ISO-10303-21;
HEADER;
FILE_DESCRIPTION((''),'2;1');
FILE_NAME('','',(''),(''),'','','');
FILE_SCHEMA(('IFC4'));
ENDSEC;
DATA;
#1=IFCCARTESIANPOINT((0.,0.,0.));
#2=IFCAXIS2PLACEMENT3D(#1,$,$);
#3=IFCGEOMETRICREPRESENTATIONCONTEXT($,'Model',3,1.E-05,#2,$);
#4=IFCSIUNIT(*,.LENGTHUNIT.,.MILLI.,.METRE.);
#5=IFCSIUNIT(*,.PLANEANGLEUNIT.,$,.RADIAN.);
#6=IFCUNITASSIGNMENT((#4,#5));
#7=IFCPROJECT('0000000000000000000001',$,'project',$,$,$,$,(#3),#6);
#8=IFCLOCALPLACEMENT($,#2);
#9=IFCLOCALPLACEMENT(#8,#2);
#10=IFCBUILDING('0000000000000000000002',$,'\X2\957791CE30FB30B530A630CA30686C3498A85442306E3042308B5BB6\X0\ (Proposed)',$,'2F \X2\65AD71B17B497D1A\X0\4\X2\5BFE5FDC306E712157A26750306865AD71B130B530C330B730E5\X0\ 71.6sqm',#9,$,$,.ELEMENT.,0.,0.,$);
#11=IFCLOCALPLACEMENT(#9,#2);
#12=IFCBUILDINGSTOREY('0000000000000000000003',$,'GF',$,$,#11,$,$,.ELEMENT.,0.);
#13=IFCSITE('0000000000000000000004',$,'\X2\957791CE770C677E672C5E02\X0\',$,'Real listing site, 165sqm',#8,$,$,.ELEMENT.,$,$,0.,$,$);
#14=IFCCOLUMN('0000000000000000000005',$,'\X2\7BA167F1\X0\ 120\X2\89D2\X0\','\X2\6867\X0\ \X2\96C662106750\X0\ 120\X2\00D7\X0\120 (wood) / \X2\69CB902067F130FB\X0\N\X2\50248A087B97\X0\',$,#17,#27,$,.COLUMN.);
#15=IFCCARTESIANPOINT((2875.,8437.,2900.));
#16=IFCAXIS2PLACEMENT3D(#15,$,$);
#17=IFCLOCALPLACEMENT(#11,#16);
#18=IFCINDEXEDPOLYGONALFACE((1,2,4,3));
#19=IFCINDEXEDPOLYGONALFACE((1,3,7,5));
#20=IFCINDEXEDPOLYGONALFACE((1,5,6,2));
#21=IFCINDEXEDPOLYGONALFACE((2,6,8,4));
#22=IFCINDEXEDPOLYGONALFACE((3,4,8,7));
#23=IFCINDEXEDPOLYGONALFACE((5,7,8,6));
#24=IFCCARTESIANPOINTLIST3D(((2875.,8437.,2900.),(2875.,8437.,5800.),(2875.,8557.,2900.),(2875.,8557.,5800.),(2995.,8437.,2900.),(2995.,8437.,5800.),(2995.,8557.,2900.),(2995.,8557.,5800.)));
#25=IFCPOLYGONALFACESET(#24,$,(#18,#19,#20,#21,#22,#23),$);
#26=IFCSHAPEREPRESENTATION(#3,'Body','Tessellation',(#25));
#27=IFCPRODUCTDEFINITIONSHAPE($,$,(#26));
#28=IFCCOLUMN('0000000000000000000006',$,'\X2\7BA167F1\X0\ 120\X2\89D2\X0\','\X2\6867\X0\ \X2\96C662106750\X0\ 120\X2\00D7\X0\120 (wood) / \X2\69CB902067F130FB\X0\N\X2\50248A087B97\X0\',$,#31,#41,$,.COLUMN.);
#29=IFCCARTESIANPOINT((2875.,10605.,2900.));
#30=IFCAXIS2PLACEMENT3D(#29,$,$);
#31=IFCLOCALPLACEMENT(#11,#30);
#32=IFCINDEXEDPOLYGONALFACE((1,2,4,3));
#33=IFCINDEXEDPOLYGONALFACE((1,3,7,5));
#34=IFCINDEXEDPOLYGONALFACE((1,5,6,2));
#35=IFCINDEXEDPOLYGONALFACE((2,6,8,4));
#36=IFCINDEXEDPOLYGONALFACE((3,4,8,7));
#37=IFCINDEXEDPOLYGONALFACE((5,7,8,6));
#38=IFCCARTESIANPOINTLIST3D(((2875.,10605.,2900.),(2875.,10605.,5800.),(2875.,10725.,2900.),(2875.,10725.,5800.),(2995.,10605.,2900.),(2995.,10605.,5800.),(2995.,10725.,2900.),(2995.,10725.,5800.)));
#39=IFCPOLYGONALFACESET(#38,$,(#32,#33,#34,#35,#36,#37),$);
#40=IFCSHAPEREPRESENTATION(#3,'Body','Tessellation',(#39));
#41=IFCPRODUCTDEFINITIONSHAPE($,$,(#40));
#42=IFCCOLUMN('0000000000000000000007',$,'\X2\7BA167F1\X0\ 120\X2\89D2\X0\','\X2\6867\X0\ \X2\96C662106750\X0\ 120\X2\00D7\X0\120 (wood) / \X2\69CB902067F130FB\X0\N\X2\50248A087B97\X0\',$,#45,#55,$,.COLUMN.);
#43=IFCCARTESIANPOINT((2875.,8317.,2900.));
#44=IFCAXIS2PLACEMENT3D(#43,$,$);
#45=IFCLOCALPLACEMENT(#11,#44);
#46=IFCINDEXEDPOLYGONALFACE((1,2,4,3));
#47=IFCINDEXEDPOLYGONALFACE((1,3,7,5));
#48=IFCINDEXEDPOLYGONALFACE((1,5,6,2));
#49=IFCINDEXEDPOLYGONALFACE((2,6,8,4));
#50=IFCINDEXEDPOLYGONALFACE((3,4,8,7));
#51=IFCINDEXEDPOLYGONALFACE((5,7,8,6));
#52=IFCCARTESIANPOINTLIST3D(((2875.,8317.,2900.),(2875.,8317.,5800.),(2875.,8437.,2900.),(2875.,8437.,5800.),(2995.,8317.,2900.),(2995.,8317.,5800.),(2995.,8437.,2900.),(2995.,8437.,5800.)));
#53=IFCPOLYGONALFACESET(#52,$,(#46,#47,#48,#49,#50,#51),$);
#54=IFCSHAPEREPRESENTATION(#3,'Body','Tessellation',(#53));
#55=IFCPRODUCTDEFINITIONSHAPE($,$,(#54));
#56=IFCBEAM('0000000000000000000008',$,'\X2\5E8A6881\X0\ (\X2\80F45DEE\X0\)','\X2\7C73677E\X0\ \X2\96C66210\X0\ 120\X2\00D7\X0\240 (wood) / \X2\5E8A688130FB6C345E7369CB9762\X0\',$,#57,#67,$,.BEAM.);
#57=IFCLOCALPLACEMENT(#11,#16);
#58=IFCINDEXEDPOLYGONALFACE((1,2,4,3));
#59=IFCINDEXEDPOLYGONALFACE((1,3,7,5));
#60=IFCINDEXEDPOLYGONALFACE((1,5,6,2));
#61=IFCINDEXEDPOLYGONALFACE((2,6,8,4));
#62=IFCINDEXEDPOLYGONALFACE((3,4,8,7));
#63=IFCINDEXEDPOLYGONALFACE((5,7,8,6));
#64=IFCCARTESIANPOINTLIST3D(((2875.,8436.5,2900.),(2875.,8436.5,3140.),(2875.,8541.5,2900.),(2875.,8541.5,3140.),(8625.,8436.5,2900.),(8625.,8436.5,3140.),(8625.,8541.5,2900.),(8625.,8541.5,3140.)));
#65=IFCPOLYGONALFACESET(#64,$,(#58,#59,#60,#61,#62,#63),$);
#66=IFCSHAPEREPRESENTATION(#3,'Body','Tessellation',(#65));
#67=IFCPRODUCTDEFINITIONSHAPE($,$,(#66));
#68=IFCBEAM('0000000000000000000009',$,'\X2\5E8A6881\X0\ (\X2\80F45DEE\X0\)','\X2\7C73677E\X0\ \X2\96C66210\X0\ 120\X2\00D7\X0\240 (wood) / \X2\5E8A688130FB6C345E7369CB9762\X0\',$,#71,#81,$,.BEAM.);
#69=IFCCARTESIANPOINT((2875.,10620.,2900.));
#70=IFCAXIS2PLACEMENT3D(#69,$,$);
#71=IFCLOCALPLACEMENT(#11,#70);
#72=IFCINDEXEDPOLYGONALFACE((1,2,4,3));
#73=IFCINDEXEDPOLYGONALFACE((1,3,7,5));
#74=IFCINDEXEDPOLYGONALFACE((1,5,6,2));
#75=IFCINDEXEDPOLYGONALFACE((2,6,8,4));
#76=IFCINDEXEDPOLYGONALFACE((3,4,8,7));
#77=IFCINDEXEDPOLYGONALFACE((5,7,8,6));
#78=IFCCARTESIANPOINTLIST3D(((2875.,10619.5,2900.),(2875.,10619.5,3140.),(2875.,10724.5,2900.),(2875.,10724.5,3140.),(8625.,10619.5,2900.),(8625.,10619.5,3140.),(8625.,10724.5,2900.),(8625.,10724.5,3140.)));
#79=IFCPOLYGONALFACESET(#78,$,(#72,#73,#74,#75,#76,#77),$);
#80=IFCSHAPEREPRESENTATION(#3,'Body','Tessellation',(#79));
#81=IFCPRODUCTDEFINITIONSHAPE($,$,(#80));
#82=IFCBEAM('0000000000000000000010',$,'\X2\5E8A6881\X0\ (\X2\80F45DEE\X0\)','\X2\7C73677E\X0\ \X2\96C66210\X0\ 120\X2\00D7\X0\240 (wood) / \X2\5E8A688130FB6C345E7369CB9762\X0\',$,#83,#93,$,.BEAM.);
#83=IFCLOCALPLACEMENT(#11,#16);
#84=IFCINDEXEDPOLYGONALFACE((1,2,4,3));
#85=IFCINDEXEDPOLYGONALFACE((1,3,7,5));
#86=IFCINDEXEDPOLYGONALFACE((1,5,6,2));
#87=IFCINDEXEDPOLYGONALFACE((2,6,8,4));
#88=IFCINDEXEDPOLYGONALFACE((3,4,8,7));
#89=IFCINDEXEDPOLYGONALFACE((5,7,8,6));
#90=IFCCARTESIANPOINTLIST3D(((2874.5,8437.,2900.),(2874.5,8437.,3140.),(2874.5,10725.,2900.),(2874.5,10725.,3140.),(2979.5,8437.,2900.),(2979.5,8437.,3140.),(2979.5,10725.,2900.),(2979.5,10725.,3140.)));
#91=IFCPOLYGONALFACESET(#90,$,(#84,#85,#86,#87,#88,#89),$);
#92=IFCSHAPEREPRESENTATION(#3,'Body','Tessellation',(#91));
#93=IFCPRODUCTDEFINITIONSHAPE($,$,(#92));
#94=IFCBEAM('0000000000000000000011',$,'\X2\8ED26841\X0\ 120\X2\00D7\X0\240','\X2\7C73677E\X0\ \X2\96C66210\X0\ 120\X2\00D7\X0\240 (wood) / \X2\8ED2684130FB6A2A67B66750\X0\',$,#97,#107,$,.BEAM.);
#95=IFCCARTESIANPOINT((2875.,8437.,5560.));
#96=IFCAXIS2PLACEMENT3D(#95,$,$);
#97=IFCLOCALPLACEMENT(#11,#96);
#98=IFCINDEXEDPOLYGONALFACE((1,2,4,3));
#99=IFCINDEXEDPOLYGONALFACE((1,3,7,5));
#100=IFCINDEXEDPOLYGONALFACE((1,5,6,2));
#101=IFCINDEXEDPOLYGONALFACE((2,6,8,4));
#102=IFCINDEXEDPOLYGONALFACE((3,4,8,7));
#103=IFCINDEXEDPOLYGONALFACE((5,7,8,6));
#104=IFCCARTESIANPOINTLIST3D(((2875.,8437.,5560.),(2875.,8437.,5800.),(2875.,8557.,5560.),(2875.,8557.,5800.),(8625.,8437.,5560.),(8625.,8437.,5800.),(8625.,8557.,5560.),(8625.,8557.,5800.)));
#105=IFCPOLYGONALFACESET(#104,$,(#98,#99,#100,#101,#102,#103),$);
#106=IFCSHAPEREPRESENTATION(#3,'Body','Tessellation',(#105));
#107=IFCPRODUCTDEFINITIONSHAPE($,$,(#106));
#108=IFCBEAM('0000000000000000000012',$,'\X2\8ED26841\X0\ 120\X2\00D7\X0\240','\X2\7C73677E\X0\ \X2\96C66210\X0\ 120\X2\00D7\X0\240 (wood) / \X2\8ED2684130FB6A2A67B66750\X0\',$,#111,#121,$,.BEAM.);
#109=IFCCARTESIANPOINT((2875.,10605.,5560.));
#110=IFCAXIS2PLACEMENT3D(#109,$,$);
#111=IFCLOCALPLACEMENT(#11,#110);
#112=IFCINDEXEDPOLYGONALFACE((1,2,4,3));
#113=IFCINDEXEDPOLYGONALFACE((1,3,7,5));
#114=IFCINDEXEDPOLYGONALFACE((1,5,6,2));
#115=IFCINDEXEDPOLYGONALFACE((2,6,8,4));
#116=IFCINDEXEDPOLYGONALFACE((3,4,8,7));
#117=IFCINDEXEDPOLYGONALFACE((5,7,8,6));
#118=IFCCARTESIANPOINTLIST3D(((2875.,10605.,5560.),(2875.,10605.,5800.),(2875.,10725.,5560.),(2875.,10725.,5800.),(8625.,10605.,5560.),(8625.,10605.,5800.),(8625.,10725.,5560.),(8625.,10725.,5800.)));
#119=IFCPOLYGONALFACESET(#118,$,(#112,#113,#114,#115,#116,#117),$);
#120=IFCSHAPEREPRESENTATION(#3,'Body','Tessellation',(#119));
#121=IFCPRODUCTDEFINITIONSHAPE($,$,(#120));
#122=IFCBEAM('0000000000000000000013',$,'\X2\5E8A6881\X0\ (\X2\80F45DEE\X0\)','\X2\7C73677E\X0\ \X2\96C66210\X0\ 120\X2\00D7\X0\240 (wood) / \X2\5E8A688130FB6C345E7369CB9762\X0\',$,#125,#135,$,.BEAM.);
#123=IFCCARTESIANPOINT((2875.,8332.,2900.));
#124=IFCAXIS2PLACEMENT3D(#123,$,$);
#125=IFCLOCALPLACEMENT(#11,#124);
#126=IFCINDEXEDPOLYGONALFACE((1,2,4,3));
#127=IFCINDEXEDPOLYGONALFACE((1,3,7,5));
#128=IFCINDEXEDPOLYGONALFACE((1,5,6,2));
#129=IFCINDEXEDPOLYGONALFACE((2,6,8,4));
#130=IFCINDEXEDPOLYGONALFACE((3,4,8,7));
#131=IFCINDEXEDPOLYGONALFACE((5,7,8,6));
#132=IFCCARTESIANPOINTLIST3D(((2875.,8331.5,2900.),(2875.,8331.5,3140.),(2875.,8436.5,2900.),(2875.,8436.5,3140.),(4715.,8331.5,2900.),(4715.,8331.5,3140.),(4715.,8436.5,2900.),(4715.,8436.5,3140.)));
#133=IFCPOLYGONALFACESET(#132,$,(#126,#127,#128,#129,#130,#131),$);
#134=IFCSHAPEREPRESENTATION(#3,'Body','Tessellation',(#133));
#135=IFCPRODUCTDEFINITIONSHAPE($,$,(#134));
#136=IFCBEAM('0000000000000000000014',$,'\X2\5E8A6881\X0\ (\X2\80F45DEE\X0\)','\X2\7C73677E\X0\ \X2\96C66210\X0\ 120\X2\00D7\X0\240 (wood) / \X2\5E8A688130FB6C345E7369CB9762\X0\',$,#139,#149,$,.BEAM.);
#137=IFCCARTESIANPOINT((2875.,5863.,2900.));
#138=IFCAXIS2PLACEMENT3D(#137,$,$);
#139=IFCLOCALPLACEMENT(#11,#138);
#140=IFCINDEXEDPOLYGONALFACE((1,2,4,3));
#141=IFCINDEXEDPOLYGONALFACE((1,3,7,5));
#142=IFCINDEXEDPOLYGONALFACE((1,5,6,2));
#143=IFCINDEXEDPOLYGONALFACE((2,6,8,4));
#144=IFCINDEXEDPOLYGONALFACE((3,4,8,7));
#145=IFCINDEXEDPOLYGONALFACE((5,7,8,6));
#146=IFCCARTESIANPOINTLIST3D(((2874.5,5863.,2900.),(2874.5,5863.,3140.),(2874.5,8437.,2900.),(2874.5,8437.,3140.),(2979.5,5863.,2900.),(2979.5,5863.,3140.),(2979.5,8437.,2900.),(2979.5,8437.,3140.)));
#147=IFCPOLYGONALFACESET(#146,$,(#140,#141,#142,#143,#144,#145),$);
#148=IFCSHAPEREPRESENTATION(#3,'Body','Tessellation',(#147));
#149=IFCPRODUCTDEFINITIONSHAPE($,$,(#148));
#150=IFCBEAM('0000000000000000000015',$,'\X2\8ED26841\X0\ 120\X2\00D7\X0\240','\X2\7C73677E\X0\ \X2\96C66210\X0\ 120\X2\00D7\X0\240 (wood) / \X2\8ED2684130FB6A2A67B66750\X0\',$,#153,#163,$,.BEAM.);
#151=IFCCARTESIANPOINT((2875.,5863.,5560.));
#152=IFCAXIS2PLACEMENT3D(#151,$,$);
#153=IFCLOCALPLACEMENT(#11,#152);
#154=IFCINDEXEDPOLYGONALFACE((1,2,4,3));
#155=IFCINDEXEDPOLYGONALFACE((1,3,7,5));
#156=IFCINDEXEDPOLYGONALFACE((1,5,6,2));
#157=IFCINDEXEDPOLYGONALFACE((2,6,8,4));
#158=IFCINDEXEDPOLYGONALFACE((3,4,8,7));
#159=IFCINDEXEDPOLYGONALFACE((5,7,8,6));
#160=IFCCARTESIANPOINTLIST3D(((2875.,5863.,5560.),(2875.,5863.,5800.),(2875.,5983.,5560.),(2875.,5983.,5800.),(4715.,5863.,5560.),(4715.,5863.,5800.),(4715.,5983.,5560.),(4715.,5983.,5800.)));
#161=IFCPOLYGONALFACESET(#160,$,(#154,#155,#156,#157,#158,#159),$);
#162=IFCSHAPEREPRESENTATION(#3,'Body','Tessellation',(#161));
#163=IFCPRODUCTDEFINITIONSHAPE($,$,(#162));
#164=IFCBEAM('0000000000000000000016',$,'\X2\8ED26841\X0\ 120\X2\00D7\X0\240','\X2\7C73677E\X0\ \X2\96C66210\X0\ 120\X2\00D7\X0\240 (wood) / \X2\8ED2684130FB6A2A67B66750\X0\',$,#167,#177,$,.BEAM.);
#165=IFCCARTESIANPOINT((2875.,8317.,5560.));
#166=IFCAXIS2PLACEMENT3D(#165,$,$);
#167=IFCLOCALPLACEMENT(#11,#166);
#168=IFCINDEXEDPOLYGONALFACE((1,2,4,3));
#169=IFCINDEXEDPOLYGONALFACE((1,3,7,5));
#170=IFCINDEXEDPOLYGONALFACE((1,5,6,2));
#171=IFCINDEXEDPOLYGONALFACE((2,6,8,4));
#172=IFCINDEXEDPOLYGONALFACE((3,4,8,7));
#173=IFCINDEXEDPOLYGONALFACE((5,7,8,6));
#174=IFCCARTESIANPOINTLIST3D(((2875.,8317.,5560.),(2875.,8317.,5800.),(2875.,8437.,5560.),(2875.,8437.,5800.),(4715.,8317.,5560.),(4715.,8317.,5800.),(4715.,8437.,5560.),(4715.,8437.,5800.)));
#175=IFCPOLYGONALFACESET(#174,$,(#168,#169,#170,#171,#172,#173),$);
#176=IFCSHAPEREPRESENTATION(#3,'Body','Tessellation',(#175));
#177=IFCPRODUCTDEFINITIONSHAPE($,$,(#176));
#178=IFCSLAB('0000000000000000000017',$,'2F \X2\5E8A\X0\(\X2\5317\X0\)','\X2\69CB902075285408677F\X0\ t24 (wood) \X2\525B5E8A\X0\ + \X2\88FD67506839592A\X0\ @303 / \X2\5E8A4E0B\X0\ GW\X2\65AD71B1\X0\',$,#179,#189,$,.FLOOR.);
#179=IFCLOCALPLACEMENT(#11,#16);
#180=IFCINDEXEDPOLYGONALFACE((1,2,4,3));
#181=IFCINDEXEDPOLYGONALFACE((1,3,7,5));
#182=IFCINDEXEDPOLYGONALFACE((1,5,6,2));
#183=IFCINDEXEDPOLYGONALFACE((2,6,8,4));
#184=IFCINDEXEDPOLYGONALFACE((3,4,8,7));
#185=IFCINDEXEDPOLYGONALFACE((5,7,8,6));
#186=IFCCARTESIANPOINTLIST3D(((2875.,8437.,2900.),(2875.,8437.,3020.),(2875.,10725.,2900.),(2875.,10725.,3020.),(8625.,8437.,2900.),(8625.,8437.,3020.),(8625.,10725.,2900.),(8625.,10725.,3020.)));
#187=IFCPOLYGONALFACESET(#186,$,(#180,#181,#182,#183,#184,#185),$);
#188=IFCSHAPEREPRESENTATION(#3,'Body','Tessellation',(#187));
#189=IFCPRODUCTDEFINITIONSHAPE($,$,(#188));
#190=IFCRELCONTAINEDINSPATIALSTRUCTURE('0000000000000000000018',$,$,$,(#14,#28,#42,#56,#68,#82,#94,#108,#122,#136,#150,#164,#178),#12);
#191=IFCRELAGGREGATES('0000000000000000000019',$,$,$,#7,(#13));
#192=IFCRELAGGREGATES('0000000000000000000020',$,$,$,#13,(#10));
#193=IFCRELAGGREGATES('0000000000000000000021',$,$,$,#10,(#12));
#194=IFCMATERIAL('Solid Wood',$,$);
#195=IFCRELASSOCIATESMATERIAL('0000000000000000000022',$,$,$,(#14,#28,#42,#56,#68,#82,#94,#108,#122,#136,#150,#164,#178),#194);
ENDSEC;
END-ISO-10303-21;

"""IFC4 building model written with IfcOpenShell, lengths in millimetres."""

from ifc_helpers import new_model, si_unit, frame, frame_2d, origin, place, context, project, spatial, rectangle, extrude, material, element, save


model = new_model("IFC4")

# Units and contexts
model_context = context("Model", 3, precision=1e-05, world=origin())
ifc_project = project(units=[si_unit("LENGTHUNIT", "METRE", prefix="MILLI"), si_unit("PLANEANGLEUNIT", "RADIAN")], contexts=[model_context])

# Site, building, storey
site_placement = place(None, origin())
site = spatial("IfcSite", under=ifc_project, at=site_placement, Name="長野県松本市", ObjectType="Real listing site, 165sqm", CompositionType="ELEMENT", RefElevation=0.0)
building_placement = place(site_placement, origin())
building = spatial("IfcBuilding", under=site, at=building_placement, Name="長野・サウナと水風呂のある家 (Proposed)", ObjectType="2F 断熱等級4対応の無垢材と断熱サッシュ 71.6sqm", CompositionType="ELEMENT", ElevationOfRefHeight=0.0, ElevationOfTerrain=0.0)
storey_placement = place(building_placement, origin())
storey = spatial("IfcBuildingStorey", under=building, at=storey_placement, Name="GF", CompositionType="ELEMENT", Elevation=0.0)

# Columns
ifc_material_1 = material(Name="Solid Wood")
column_1_placement = place(storey_placement, frame((2875.0, 8437.0, 2900.0)))
element("IfcColumn", 1, at=column_1_placement, inside=storey, material=ifc_material_1, Name="管柱 120角", Description="桧 集成材 120×120 (wood) / 構造柱・N値計算", PredefinedType="COLUMN", context=model_context, shape_type="SweptSolid", body=[
    extrude(rectangle(XDim=120.0, YDim=120.0, at=frame_2d((60.0, 60.0))), frame((2875.0, 8437.0, 2900.0)), (0.0, 0.0, 1.0), 2900.0),
])
column_2_placement = place(storey_placement, frame((2875.0, 10605.0, 2900.0)))
element("IfcColumn", 2, at=column_2_placement, inside=storey, material=ifc_material_1, Name="管柱 120角", Description="桧 集成材 120×120 (wood) / 構造柱・N値計算", PredefinedType="COLUMN", context=model_context, shape_type="SweptSolid", body=[
    extrude(rectangle(XDim=120.0, YDim=120.0, at=frame_2d((60.0, 60.0))), frame((2875.0, 10605.0, 2900.0)), (0.0, 0.0, 1.0), 2900.0),
])
column_3_placement = place(storey_placement, frame((2875.0, 8317.0, 2900.0)))
element("IfcColumn", 3, at=column_3_placement, inside=storey, material=ifc_material_1, Name="管柱 120角", Description="桧 集成材 120×120 (wood) / 構造柱・N値計算", PredefinedType="COLUMN", context=model_context, shape_type="SweptSolid", body=[
    extrude(rectangle(XDim=120.0, YDim=120.0, at=frame_2d((60.0, 60.0))), frame((2875.0, 8317.0, 2900.0)), (0.0, 0.0, 1.0), 2900.0),
])

# Beams
beam_1_placement = place(storey_placement, frame((2875.0, 8437.0, 2900.0)))
element("IfcBeam", 4, at=beam_1_placement, inside=storey, material=ifc_material_1, Name="床梁 (胴差)", Description="米松 集成 120×240 (wood) / 床梁・水平構面", PredefinedType="BEAM", context=model_context, shape_type="SweptSolid", body=[
    extrude(rectangle(XDim=5750.0, YDim=105.0, at=frame_2d((2875.0, 52.0))), frame((2875.0, 8437.0, 2900.0)), (0.0, 0.0, 1.0), 240.0),
])
beam_2_placement = place(storey_placement, frame((2875.0, 10620.0, 2900.0)))
element("IfcBeam", 5, at=beam_2_placement, inside=storey, material=ifc_material_1, Name="床梁 (胴差)", Description="米松 集成 120×240 (wood) / 床梁・水平構面", PredefinedType="BEAM", context=model_context, shape_type="SweptSolid", body=[
    extrude(rectangle(XDim=5750.0, YDim=105.0, at=frame_2d((2875.0, 52.0))), frame((2875.0, 10620.0, 2900.0)), (0.0, 0.0, 1.0), 240.0),
])
beam_3_placement = place(storey_placement, frame((2875.0, 8437.0, 2900.0)))
element("IfcBeam", 6, at=beam_3_placement, inside=storey, material=ifc_material_1, Name="床梁 (胴差)", Description="米松 集成 120×240 (wood) / 床梁・水平構面", PredefinedType="BEAM", context=model_context, shape_type="SweptSolid", body=[
    extrude(rectangle(XDim=105.0, YDim=2288.0, at=frame_2d((52.0, 1144.0))), frame((2875.0, 8437.0, 2900.0)), (0.0, 0.0, 1.0), 240.0),
])
beam_4_placement = place(storey_placement, frame((2875.0, 8437.0, 5560.0)))
element("IfcBeam", 7, at=beam_4_placement, inside=storey, material=ifc_material_1, Name="軒桁 120×240", Description="米松 集成 120×240 (wood) / 軒桁・横架材", PredefinedType="BEAM", context=model_context, shape_type="SweptSolid", body=[
    extrude(rectangle(XDim=5750.0, YDim=120.0, at=frame_2d((2875.0, 60.0))), frame((2875.0, 8437.0, 5560.0)), (0.0, 0.0, 1.0), 240.0),
])
beam_5_placement = place(storey_placement, frame((2875.0, 10605.0, 5560.0)))
element("IfcBeam", 8, at=beam_5_placement, inside=storey, material=ifc_material_1, Name="軒桁 120×240", Description="米松 集成 120×240 (wood) / 軒桁・横架材", PredefinedType="BEAM", context=model_context, shape_type="SweptSolid", body=[
    extrude(rectangle(XDim=5750.0, YDim=120.0, at=frame_2d((2875.0, 60.0))), frame((2875.0, 10605.0, 5560.0)), (0.0, 0.0, 1.0), 240.0),
])
beam_6_placement = place(storey_placement, frame((2875.0, 8332.0, 2900.0)))
element("IfcBeam", 9, at=beam_6_placement, inside=storey, material=ifc_material_1, Name="床梁 (胴差)", Description="米松 集成 120×240 (wood) / 床梁・水平構面", PredefinedType="BEAM", context=model_context, shape_type="SweptSolid", body=[
    extrude(rectangle(XDim=1840.0, YDim=105.0, at=frame_2d((920.0, 52.0))), frame((2875.0, 8332.0, 2900.0)), (0.0, 0.0, 1.0), 240.0),
])
beam_7_placement = place(storey_placement, frame((2875.0, 5863.0, 2900.0)))
element("IfcBeam", 10, at=beam_7_placement, inside=storey, material=ifc_material_1, Name="床梁 (胴差)", Description="米松 集成 120×240 (wood) / 床梁・水平構面", PredefinedType="BEAM", context=model_context, shape_type="SweptSolid", body=[
    extrude(rectangle(XDim=105.0, YDim=2574.0, at=frame_2d((52.0, 1287.0))), frame((2875.0, 5863.0, 2900.0)), (0.0, 0.0, 1.0), 240.0),
])
beam_8_placement = place(storey_placement, frame((2875.0, 5863.0, 5560.0)))
element("IfcBeam", 11, at=beam_8_placement, inside=storey, material=ifc_material_1, Name="軒桁 120×240", Description="米松 集成 120×240 (wood) / 軒桁・横架材", PredefinedType="BEAM", context=model_context, shape_type="SweptSolid", body=[
    extrude(rectangle(XDim=1840.0, YDim=120.0, at=frame_2d((920.0, 60.0))), frame((2875.0, 5863.0, 5560.0)), (0.0, 0.0, 1.0), 240.0),
])
beam_9_placement = place(storey_placement, frame((2875.0, 8317.0, 5560.0)))
element("IfcBeam", 12, at=beam_9_placement, inside=storey, material=ifc_material_1, Name="軒桁 120×240", Description="米松 集成 120×240 (wood) / 軒桁・横架材", PredefinedType="BEAM", context=model_context, shape_type="SweptSolid", body=[
    extrude(rectangle(XDim=1840.0, YDim=120.0, at=frame_2d((920.0, 60.0))), frame((2875.0, 8317.0, 5560.0)), (0.0, 0.0, 1.0), 240.0),
])

# Slab
slab_placement = place(storey_placement, frame((2875.0, 8437.0, 2900.0)))
element("IfcSlab", 13, at=slab_placement, inside=storey, material=ifc_material_1, Name="2F 床(北)", Description="構造用合板 t24 (wood) 剛床 + 製材根太 @303 / 床下 GW断熱", PredefinedType="FLOOR", context=model_context, shape_type="SweptSolid", body=[
    extrude(rectangle(XDim=5750.0, YDim=2288.0, at=frame_2d((2875.0, 1144.0))), frame((2875.0, 8437.0, 2900.0)), (0.0, 0.0, 1.0), 120.0),
])

save(model, "model.ifc")
